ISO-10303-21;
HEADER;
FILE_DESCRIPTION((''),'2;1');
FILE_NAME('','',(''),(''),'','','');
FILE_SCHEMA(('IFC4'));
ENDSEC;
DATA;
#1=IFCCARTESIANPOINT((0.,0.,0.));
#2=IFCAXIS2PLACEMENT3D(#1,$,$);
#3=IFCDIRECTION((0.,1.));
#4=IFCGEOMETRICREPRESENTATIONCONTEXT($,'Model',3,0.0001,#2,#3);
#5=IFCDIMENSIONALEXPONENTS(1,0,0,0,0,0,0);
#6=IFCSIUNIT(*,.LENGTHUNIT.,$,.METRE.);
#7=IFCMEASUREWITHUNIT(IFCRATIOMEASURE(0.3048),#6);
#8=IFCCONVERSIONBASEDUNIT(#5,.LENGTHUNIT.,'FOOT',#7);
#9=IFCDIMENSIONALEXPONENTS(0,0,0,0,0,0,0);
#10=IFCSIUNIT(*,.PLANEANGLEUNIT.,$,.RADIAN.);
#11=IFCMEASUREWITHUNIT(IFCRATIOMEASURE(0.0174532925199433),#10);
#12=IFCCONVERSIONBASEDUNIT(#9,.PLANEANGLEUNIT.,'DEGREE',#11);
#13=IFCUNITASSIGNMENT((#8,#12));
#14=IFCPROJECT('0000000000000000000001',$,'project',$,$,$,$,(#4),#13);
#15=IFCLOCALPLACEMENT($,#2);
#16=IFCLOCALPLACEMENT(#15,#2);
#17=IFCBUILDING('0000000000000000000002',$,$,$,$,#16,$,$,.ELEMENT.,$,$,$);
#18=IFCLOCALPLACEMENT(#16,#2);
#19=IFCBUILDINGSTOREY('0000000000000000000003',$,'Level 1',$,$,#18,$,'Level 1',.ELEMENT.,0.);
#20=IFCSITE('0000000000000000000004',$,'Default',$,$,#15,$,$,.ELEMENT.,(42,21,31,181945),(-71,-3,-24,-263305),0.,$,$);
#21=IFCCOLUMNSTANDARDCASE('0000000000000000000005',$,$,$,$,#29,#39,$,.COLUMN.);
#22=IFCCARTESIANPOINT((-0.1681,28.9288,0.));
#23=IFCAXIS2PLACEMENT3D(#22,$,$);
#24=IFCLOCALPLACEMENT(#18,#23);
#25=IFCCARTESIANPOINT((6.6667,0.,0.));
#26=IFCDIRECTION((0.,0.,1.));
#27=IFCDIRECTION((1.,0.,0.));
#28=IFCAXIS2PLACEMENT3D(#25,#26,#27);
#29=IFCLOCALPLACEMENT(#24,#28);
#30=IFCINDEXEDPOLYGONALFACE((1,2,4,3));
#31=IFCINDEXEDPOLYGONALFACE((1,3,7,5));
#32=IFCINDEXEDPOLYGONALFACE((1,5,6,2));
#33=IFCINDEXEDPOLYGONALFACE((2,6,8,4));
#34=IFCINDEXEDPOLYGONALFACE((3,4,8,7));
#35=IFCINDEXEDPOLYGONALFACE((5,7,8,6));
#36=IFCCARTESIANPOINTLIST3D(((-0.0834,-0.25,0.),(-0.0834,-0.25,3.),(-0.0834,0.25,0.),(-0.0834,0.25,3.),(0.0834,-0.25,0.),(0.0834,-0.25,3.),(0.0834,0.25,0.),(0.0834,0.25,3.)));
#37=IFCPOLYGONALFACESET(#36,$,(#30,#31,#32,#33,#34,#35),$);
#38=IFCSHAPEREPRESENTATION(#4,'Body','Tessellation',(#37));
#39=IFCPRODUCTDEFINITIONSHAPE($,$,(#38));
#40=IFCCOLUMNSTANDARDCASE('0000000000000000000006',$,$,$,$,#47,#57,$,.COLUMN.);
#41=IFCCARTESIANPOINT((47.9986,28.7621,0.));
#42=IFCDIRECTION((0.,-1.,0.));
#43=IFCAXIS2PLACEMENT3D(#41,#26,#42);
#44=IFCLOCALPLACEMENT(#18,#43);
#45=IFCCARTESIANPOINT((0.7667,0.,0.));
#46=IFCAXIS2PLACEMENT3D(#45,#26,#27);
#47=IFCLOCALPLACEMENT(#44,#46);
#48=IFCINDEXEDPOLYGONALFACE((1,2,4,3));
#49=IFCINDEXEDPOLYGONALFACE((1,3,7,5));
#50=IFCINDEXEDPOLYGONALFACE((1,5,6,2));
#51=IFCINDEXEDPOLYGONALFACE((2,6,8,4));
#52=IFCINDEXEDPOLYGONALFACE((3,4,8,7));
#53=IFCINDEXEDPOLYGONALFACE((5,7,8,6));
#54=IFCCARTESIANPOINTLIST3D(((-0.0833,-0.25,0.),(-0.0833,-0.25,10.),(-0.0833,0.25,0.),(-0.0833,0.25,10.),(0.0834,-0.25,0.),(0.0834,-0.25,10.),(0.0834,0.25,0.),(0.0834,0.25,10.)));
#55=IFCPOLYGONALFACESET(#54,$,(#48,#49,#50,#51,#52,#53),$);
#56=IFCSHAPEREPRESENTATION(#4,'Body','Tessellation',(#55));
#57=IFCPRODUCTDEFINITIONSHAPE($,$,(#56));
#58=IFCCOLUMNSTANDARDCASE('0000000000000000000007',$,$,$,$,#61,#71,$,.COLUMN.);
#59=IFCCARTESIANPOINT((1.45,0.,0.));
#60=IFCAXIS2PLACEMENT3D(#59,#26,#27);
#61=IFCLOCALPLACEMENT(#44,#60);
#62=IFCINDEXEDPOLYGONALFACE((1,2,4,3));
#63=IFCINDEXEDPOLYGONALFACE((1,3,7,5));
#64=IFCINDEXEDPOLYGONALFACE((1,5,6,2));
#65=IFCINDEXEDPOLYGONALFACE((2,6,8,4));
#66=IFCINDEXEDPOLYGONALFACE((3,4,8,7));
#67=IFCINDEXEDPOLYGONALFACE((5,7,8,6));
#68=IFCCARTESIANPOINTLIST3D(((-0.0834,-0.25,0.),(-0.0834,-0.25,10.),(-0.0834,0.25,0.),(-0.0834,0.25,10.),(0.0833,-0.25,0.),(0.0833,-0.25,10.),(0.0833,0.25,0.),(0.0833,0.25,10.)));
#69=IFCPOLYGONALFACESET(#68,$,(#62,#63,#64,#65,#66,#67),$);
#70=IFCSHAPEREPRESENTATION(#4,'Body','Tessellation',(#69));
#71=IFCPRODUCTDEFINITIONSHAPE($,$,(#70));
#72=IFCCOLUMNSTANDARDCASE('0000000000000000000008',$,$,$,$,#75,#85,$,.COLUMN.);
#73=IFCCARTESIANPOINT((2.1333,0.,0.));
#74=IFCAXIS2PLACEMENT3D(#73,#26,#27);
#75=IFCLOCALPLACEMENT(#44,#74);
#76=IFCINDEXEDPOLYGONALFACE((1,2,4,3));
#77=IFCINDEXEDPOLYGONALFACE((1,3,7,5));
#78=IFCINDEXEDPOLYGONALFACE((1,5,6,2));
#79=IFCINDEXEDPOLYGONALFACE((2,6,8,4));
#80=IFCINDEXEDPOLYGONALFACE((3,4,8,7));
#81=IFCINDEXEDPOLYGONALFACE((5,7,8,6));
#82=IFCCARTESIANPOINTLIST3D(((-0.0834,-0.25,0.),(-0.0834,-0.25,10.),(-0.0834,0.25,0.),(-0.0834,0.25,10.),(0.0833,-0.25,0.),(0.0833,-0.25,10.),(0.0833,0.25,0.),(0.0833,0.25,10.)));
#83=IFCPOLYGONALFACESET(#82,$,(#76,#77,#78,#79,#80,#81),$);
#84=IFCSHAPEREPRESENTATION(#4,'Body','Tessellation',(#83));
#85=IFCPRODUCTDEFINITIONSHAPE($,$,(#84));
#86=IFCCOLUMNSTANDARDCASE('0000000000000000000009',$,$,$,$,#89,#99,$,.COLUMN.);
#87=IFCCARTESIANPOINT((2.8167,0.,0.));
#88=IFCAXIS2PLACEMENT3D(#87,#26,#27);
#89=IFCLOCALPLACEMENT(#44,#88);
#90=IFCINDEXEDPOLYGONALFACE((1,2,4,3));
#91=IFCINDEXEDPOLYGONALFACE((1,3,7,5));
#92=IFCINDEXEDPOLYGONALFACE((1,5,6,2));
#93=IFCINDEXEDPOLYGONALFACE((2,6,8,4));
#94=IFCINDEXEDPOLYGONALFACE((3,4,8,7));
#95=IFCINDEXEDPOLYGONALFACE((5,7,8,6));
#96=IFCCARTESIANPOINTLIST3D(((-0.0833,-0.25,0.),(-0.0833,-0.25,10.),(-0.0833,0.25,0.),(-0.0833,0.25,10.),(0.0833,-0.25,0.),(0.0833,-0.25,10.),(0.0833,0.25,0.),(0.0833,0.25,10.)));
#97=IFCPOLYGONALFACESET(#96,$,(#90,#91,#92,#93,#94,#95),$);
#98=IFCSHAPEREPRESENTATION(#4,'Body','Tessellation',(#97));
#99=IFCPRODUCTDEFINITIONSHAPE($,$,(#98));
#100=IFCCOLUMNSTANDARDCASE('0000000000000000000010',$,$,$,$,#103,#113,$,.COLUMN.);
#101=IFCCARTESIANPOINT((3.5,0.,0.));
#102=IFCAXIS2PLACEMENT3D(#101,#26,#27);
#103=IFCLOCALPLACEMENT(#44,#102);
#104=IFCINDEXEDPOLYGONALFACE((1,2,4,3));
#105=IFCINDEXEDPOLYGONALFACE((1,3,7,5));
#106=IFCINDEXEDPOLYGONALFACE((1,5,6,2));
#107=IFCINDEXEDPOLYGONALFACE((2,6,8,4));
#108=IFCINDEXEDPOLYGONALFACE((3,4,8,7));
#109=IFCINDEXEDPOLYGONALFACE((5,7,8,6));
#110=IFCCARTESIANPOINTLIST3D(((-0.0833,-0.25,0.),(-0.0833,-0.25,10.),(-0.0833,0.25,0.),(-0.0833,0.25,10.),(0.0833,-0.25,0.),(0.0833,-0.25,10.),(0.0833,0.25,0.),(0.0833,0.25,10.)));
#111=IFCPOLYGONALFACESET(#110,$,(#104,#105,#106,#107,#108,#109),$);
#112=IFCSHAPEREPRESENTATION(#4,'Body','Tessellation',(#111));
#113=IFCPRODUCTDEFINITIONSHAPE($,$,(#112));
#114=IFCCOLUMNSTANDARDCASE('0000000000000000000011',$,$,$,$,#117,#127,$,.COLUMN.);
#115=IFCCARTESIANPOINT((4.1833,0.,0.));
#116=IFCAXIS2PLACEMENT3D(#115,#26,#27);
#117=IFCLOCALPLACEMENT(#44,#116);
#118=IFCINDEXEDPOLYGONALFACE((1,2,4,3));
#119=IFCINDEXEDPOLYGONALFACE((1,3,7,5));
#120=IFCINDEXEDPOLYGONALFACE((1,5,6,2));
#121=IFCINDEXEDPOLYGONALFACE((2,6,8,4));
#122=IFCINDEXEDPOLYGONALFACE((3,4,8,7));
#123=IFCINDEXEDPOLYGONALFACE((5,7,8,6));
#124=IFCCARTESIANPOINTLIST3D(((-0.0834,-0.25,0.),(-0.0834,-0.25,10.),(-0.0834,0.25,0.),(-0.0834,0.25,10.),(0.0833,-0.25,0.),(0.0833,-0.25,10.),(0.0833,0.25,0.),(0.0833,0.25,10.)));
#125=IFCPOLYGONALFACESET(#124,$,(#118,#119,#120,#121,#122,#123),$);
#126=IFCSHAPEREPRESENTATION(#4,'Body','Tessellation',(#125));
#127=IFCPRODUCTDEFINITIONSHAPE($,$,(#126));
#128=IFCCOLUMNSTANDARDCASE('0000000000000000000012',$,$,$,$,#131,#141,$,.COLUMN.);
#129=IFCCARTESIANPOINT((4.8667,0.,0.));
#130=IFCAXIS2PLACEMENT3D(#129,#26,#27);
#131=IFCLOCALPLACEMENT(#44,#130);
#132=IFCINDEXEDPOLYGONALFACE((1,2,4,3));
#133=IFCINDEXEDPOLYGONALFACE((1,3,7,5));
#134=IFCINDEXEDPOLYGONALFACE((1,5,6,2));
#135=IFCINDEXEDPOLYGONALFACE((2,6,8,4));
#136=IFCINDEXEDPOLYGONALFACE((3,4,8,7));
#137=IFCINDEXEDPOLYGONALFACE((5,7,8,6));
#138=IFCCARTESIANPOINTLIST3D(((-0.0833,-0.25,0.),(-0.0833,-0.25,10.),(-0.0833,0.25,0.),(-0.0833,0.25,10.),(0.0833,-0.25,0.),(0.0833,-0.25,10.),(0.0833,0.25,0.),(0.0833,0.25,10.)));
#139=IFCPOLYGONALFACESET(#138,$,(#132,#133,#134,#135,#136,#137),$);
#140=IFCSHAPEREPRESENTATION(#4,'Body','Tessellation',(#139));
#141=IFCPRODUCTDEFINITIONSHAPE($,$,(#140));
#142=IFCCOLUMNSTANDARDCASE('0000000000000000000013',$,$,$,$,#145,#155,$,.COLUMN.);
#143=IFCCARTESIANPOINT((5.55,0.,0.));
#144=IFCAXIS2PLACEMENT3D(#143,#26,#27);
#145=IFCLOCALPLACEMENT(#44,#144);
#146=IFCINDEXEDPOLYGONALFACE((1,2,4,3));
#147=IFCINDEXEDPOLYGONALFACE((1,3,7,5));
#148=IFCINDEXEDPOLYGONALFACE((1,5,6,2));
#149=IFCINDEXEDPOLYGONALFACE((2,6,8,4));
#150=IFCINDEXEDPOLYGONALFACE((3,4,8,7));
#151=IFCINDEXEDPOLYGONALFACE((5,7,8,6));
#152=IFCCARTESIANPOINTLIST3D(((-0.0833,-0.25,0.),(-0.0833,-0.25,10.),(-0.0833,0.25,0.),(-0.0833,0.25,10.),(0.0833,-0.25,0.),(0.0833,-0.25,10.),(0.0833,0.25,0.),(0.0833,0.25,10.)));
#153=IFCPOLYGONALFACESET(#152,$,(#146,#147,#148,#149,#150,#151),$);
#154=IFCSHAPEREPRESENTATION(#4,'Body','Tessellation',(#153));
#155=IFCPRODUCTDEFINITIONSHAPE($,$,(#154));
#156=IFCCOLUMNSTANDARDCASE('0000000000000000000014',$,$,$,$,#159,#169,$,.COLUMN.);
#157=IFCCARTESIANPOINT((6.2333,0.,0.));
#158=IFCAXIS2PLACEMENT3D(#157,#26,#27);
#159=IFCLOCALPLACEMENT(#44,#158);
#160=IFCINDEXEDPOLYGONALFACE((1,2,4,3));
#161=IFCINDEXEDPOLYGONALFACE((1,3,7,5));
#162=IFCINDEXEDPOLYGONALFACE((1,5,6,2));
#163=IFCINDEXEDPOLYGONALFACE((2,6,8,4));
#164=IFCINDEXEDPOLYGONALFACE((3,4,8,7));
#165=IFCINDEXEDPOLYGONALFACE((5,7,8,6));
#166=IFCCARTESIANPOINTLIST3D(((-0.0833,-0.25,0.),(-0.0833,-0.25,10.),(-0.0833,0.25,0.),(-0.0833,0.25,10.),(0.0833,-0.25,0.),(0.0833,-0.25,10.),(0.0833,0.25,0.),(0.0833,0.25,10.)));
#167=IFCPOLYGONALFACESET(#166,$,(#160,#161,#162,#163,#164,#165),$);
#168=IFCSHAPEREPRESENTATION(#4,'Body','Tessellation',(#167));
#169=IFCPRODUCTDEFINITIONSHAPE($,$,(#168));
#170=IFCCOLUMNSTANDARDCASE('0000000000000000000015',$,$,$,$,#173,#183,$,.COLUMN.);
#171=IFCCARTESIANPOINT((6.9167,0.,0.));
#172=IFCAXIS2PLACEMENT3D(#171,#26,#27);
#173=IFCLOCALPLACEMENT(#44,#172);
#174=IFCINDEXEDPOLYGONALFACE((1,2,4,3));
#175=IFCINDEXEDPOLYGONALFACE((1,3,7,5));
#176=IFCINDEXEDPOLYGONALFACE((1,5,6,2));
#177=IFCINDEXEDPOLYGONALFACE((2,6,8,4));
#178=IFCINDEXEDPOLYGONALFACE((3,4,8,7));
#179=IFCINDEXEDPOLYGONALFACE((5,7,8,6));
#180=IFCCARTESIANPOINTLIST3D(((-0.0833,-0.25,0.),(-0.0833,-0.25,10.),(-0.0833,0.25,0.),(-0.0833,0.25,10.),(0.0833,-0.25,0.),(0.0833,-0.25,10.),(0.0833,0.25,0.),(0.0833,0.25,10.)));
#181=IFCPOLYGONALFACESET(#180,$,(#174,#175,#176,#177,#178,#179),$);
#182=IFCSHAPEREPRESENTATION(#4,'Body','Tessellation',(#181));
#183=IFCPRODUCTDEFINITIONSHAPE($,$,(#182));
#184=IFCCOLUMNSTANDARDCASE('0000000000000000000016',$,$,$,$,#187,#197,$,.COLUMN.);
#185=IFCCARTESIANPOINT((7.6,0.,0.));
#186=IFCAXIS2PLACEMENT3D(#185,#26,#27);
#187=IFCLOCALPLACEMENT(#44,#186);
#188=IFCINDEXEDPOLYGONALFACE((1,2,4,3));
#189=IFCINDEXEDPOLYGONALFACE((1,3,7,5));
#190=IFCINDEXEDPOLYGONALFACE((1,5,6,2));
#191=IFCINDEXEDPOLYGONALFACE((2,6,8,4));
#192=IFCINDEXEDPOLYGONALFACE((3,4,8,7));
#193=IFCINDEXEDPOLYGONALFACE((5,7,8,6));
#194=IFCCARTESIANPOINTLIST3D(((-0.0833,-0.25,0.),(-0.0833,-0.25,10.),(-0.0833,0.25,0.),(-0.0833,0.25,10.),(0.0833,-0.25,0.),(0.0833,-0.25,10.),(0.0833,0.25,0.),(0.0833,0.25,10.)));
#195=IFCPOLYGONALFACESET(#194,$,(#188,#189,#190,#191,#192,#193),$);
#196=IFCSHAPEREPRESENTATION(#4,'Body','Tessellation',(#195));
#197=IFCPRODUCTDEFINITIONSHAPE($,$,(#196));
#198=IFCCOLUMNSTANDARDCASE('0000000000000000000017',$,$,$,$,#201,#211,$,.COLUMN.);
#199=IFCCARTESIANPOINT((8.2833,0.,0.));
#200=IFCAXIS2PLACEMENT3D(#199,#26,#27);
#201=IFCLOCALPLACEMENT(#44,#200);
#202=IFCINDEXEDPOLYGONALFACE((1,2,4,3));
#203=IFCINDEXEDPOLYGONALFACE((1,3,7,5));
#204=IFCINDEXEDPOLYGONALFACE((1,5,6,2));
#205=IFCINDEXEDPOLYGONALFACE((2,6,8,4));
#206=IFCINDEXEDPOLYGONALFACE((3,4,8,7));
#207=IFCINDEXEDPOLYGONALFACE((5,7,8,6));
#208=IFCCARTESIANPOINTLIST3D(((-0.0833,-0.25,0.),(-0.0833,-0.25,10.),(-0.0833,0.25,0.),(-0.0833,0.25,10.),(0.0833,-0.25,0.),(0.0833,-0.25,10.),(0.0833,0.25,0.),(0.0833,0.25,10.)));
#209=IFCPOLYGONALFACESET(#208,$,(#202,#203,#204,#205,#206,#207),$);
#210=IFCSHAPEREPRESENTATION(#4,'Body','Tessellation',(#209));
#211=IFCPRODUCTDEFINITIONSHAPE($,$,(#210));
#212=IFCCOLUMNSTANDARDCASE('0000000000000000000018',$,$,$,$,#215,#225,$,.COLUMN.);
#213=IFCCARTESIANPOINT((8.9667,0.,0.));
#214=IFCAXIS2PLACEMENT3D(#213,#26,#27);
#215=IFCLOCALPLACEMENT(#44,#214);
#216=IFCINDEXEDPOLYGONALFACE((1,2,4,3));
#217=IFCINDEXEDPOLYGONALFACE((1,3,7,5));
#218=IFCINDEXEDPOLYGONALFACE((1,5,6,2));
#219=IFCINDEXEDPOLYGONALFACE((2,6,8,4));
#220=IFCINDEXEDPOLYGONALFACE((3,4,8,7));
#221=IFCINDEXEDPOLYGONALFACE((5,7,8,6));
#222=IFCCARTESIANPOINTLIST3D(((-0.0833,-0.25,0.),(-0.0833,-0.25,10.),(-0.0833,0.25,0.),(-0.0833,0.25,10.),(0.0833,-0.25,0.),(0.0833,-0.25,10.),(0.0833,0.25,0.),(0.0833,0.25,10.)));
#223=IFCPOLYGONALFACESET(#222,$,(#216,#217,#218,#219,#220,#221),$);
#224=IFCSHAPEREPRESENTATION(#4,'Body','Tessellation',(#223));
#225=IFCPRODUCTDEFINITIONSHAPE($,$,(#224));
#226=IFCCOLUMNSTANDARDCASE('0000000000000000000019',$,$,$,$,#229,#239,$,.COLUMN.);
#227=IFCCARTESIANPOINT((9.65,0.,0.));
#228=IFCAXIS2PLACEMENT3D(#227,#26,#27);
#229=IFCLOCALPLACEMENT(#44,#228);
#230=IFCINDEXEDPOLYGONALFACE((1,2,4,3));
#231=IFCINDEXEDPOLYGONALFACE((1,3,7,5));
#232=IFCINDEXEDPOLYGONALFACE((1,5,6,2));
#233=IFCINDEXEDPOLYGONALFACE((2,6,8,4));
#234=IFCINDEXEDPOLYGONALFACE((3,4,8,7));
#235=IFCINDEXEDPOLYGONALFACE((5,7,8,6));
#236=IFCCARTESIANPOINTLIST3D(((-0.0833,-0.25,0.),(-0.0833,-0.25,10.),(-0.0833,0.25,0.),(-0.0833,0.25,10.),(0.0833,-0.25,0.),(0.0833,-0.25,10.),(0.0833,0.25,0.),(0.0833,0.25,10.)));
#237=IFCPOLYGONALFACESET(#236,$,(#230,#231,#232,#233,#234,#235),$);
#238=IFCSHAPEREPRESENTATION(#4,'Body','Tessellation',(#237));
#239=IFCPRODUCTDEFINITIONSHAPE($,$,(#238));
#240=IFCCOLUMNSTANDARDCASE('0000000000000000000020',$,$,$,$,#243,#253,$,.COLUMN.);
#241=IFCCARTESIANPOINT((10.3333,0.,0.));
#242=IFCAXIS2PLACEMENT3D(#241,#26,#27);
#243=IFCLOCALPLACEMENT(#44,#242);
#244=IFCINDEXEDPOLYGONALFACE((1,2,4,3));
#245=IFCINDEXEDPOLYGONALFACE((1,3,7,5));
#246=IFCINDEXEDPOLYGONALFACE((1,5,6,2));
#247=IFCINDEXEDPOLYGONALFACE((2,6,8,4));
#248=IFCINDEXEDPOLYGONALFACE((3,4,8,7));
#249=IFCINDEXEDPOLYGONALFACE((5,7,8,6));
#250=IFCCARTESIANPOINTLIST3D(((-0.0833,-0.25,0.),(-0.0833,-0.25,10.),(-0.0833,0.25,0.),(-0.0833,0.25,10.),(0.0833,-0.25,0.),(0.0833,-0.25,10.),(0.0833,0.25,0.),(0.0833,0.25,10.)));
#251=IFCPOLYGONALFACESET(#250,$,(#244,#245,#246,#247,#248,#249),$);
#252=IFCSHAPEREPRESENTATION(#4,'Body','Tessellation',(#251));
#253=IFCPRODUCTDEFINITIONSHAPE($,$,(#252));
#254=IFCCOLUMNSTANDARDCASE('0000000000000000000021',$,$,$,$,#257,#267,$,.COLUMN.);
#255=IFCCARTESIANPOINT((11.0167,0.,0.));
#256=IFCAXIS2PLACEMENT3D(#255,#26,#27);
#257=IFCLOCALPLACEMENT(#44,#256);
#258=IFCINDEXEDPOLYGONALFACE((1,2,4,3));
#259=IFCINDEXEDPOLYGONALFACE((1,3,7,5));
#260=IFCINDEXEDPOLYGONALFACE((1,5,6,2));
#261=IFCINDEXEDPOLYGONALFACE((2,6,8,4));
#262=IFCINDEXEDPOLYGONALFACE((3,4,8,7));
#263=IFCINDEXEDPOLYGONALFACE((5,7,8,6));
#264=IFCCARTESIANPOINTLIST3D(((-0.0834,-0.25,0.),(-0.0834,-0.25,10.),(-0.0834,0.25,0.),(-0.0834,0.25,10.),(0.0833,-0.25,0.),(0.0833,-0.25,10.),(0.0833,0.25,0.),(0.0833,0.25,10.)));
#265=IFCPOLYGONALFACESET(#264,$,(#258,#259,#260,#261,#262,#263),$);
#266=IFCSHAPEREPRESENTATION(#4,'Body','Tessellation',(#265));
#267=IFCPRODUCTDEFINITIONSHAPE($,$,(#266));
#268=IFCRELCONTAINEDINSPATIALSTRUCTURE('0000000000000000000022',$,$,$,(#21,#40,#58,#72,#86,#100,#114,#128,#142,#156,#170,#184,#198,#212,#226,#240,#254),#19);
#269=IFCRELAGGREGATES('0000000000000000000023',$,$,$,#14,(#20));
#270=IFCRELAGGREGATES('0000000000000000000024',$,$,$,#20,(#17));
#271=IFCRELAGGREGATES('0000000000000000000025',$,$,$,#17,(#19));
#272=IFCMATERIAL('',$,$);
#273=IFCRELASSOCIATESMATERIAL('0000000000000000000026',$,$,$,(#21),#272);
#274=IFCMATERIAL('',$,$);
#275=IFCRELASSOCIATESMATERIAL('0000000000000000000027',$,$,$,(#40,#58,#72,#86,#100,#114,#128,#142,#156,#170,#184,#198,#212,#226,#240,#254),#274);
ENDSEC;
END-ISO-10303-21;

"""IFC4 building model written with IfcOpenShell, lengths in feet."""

from ifc_helpers import new_model, entity, si_unit, converted_unit, direction, frame, origin, place, context, project, spatial, rectangle, extrude, material, element, save


model = new_model("IFC4")

# Units and contexts
model_context = context("Model", 3, precision=0.0001, world=origin(), true_north=direction((0.0, 1.0)))
ifc_project = project(units=[converted_unit("LENGTHUNIT", "FOOT", entity("IfcRatioMeasure", 0.3048), si_unit("LENGTHUNIT", "METRE"), dimensions=[1, 0, 0, 0, 0, 0, 0]), converted_unit("PLANEANGLEUNIT", "DEGREE", entity("IfcRatioMeasure", 0.0174532925199433), si_unit("PLANEANGLEUNIT", "RADIAN"), dimensions=[0, 0, 0, 0, 0, 0, 0])], contexts=[model_context])

# Site, building, storey
site_placement = place(None, origin())
site = spatial("IfcSite", under=ifc_project, at=site_placement, Name="Default", CompositionType="ELEMENT", RefLatitude=(42, 21, 31, 181945), RefLongitude=(-71, -3, -24, -263305), RefElevation=0.0)
building_placement = place(site_placement, origin())
building = spatial("IfcBuilding", under=site, at=building_placement, CompositionType="ELEMENT")
storey_placement = place(building_placement, origin())
storey = spatial("IfcBuildingStorey", under=building, at=storey_placement, Name="Level 1", LongName="Level 1", CompositionType="ELEMENT", Elevation=0.0)

# Columns
ifc_material_1 = material(Name="")
placement = place(storey_placement, frame((-0.1681, 28.9288, 0.0)))
for number, where, z_axis, x_axis in (
    (1, (6.6667, 0.0, 0.0), (0.0, 0.0, 1.0), (1.0, 0.0, 0.0)),
):
    element("IfcColumnStandardCase", number, at=place(placement, frame(where, z_axis=z_axis, x_axis=x_axis)), inside=storey, material=ifc_material_1, PredefinedType="COLUMN", context=model_context, shape_type="SweptSolid", body=[
        extrude(rectangle(XDim=0.1667, YDim=0.5), origin(), (0.0, 0.0, 1.0), 3.0),
    ])
ifc_material_2 = material(Name="")
wall_placement = place(storey_placement, frame((47.9986, 28.7621, 0.0), z_axis=(0.0, 0.0, 1.0), x_axis=(0.0, -1.0, 0.0)))
for number, where, z_axis, x_axis in (
    (2, (0.7667, 0.0, 0.0), (0.0, 0.0, 1.0), (1.0, 0.0, 0.0)),
    (3, (1.45, 0.0, 0.0), (0.0, 0.0, 1.0), (1.0, 0.0, 0.0)),
    (4, (2.1333, 0.0, 0.0), (0.0, 0.0, 1.0), (1.0, 0.0, 0.0)),
    (5, (2.8167, 0.0, 0.0), (0.0, 0.0, 1.0), (1.0, 0.0, 0.0)),
    (6, (3.5, 0.0, 0.0), (0.0, 0.0, 1.0), (1.0, 0.0, 0.0)),
    (7, (4.1833, 0.0, 0.0), (0.0, 0.0, 1.0), (1.0, 0.0, 0.0)),
    (8, (4.8667, 0.0, 0.0), (0.0, 0.0, 1.0), (1.0, 0.0, 0.0)),
    (9, (5.55, 0.0, 0.0), (0.0, 0.0, 1.0), (1.0, 0.0, 0.0)),
    (10, (6.2333, 0.0, 0.0), (0.0, 0.0, 1.0), (1.0, 0.0, 0.0)),
    (11, (6.9167, 0.0, 0.0), (0.0, 0.0, 1.0), (1.0, 0.0, 0.0)),
    (12, (7.6, 0.0, 0.0), (0.0, 0.0, 1.0), (1.0, 0.0, 0.0)),
    (13, (8.2833, 0.0, 0.0), (0.0, 0.0, 1.0), (1.0, 0.0, 0.0)),
    (14, (8.9667, 0.0, 0.0), (0.0, 0.0, 1.0), (1.0, 0.0, 0.0)),
    (15, (9.65, 0.0, 0.0), (0.0, 0.0, 1.0), (1.0, 0.0, 0.0)),
    (16, (10.3333, 0.0, 0.0), (0.0, 0.0, 1.0), (1.0, 0.0, 0.0)),
    (17, (11.0167, 0.0, 0.0), (0.0, 0.0, 1.0), (1.0, 0.0, 0.0)),
):
    element("IfcColumnStandardCase", number, at=place(wall_placement, frame(where, z_axis=z_axis, x_axis=x_axis)), inside=storey, material=ifc_material_2, PredefinedType="COLUMN", context=model_context, shape_type="SweptSolid", body=[
        extrude(rectangle(XDim=0.1667, YDim=0.5), origin(), (0.0, 0.0, 1.0), 10.0),
    ])

save(model, "model.ifc")
